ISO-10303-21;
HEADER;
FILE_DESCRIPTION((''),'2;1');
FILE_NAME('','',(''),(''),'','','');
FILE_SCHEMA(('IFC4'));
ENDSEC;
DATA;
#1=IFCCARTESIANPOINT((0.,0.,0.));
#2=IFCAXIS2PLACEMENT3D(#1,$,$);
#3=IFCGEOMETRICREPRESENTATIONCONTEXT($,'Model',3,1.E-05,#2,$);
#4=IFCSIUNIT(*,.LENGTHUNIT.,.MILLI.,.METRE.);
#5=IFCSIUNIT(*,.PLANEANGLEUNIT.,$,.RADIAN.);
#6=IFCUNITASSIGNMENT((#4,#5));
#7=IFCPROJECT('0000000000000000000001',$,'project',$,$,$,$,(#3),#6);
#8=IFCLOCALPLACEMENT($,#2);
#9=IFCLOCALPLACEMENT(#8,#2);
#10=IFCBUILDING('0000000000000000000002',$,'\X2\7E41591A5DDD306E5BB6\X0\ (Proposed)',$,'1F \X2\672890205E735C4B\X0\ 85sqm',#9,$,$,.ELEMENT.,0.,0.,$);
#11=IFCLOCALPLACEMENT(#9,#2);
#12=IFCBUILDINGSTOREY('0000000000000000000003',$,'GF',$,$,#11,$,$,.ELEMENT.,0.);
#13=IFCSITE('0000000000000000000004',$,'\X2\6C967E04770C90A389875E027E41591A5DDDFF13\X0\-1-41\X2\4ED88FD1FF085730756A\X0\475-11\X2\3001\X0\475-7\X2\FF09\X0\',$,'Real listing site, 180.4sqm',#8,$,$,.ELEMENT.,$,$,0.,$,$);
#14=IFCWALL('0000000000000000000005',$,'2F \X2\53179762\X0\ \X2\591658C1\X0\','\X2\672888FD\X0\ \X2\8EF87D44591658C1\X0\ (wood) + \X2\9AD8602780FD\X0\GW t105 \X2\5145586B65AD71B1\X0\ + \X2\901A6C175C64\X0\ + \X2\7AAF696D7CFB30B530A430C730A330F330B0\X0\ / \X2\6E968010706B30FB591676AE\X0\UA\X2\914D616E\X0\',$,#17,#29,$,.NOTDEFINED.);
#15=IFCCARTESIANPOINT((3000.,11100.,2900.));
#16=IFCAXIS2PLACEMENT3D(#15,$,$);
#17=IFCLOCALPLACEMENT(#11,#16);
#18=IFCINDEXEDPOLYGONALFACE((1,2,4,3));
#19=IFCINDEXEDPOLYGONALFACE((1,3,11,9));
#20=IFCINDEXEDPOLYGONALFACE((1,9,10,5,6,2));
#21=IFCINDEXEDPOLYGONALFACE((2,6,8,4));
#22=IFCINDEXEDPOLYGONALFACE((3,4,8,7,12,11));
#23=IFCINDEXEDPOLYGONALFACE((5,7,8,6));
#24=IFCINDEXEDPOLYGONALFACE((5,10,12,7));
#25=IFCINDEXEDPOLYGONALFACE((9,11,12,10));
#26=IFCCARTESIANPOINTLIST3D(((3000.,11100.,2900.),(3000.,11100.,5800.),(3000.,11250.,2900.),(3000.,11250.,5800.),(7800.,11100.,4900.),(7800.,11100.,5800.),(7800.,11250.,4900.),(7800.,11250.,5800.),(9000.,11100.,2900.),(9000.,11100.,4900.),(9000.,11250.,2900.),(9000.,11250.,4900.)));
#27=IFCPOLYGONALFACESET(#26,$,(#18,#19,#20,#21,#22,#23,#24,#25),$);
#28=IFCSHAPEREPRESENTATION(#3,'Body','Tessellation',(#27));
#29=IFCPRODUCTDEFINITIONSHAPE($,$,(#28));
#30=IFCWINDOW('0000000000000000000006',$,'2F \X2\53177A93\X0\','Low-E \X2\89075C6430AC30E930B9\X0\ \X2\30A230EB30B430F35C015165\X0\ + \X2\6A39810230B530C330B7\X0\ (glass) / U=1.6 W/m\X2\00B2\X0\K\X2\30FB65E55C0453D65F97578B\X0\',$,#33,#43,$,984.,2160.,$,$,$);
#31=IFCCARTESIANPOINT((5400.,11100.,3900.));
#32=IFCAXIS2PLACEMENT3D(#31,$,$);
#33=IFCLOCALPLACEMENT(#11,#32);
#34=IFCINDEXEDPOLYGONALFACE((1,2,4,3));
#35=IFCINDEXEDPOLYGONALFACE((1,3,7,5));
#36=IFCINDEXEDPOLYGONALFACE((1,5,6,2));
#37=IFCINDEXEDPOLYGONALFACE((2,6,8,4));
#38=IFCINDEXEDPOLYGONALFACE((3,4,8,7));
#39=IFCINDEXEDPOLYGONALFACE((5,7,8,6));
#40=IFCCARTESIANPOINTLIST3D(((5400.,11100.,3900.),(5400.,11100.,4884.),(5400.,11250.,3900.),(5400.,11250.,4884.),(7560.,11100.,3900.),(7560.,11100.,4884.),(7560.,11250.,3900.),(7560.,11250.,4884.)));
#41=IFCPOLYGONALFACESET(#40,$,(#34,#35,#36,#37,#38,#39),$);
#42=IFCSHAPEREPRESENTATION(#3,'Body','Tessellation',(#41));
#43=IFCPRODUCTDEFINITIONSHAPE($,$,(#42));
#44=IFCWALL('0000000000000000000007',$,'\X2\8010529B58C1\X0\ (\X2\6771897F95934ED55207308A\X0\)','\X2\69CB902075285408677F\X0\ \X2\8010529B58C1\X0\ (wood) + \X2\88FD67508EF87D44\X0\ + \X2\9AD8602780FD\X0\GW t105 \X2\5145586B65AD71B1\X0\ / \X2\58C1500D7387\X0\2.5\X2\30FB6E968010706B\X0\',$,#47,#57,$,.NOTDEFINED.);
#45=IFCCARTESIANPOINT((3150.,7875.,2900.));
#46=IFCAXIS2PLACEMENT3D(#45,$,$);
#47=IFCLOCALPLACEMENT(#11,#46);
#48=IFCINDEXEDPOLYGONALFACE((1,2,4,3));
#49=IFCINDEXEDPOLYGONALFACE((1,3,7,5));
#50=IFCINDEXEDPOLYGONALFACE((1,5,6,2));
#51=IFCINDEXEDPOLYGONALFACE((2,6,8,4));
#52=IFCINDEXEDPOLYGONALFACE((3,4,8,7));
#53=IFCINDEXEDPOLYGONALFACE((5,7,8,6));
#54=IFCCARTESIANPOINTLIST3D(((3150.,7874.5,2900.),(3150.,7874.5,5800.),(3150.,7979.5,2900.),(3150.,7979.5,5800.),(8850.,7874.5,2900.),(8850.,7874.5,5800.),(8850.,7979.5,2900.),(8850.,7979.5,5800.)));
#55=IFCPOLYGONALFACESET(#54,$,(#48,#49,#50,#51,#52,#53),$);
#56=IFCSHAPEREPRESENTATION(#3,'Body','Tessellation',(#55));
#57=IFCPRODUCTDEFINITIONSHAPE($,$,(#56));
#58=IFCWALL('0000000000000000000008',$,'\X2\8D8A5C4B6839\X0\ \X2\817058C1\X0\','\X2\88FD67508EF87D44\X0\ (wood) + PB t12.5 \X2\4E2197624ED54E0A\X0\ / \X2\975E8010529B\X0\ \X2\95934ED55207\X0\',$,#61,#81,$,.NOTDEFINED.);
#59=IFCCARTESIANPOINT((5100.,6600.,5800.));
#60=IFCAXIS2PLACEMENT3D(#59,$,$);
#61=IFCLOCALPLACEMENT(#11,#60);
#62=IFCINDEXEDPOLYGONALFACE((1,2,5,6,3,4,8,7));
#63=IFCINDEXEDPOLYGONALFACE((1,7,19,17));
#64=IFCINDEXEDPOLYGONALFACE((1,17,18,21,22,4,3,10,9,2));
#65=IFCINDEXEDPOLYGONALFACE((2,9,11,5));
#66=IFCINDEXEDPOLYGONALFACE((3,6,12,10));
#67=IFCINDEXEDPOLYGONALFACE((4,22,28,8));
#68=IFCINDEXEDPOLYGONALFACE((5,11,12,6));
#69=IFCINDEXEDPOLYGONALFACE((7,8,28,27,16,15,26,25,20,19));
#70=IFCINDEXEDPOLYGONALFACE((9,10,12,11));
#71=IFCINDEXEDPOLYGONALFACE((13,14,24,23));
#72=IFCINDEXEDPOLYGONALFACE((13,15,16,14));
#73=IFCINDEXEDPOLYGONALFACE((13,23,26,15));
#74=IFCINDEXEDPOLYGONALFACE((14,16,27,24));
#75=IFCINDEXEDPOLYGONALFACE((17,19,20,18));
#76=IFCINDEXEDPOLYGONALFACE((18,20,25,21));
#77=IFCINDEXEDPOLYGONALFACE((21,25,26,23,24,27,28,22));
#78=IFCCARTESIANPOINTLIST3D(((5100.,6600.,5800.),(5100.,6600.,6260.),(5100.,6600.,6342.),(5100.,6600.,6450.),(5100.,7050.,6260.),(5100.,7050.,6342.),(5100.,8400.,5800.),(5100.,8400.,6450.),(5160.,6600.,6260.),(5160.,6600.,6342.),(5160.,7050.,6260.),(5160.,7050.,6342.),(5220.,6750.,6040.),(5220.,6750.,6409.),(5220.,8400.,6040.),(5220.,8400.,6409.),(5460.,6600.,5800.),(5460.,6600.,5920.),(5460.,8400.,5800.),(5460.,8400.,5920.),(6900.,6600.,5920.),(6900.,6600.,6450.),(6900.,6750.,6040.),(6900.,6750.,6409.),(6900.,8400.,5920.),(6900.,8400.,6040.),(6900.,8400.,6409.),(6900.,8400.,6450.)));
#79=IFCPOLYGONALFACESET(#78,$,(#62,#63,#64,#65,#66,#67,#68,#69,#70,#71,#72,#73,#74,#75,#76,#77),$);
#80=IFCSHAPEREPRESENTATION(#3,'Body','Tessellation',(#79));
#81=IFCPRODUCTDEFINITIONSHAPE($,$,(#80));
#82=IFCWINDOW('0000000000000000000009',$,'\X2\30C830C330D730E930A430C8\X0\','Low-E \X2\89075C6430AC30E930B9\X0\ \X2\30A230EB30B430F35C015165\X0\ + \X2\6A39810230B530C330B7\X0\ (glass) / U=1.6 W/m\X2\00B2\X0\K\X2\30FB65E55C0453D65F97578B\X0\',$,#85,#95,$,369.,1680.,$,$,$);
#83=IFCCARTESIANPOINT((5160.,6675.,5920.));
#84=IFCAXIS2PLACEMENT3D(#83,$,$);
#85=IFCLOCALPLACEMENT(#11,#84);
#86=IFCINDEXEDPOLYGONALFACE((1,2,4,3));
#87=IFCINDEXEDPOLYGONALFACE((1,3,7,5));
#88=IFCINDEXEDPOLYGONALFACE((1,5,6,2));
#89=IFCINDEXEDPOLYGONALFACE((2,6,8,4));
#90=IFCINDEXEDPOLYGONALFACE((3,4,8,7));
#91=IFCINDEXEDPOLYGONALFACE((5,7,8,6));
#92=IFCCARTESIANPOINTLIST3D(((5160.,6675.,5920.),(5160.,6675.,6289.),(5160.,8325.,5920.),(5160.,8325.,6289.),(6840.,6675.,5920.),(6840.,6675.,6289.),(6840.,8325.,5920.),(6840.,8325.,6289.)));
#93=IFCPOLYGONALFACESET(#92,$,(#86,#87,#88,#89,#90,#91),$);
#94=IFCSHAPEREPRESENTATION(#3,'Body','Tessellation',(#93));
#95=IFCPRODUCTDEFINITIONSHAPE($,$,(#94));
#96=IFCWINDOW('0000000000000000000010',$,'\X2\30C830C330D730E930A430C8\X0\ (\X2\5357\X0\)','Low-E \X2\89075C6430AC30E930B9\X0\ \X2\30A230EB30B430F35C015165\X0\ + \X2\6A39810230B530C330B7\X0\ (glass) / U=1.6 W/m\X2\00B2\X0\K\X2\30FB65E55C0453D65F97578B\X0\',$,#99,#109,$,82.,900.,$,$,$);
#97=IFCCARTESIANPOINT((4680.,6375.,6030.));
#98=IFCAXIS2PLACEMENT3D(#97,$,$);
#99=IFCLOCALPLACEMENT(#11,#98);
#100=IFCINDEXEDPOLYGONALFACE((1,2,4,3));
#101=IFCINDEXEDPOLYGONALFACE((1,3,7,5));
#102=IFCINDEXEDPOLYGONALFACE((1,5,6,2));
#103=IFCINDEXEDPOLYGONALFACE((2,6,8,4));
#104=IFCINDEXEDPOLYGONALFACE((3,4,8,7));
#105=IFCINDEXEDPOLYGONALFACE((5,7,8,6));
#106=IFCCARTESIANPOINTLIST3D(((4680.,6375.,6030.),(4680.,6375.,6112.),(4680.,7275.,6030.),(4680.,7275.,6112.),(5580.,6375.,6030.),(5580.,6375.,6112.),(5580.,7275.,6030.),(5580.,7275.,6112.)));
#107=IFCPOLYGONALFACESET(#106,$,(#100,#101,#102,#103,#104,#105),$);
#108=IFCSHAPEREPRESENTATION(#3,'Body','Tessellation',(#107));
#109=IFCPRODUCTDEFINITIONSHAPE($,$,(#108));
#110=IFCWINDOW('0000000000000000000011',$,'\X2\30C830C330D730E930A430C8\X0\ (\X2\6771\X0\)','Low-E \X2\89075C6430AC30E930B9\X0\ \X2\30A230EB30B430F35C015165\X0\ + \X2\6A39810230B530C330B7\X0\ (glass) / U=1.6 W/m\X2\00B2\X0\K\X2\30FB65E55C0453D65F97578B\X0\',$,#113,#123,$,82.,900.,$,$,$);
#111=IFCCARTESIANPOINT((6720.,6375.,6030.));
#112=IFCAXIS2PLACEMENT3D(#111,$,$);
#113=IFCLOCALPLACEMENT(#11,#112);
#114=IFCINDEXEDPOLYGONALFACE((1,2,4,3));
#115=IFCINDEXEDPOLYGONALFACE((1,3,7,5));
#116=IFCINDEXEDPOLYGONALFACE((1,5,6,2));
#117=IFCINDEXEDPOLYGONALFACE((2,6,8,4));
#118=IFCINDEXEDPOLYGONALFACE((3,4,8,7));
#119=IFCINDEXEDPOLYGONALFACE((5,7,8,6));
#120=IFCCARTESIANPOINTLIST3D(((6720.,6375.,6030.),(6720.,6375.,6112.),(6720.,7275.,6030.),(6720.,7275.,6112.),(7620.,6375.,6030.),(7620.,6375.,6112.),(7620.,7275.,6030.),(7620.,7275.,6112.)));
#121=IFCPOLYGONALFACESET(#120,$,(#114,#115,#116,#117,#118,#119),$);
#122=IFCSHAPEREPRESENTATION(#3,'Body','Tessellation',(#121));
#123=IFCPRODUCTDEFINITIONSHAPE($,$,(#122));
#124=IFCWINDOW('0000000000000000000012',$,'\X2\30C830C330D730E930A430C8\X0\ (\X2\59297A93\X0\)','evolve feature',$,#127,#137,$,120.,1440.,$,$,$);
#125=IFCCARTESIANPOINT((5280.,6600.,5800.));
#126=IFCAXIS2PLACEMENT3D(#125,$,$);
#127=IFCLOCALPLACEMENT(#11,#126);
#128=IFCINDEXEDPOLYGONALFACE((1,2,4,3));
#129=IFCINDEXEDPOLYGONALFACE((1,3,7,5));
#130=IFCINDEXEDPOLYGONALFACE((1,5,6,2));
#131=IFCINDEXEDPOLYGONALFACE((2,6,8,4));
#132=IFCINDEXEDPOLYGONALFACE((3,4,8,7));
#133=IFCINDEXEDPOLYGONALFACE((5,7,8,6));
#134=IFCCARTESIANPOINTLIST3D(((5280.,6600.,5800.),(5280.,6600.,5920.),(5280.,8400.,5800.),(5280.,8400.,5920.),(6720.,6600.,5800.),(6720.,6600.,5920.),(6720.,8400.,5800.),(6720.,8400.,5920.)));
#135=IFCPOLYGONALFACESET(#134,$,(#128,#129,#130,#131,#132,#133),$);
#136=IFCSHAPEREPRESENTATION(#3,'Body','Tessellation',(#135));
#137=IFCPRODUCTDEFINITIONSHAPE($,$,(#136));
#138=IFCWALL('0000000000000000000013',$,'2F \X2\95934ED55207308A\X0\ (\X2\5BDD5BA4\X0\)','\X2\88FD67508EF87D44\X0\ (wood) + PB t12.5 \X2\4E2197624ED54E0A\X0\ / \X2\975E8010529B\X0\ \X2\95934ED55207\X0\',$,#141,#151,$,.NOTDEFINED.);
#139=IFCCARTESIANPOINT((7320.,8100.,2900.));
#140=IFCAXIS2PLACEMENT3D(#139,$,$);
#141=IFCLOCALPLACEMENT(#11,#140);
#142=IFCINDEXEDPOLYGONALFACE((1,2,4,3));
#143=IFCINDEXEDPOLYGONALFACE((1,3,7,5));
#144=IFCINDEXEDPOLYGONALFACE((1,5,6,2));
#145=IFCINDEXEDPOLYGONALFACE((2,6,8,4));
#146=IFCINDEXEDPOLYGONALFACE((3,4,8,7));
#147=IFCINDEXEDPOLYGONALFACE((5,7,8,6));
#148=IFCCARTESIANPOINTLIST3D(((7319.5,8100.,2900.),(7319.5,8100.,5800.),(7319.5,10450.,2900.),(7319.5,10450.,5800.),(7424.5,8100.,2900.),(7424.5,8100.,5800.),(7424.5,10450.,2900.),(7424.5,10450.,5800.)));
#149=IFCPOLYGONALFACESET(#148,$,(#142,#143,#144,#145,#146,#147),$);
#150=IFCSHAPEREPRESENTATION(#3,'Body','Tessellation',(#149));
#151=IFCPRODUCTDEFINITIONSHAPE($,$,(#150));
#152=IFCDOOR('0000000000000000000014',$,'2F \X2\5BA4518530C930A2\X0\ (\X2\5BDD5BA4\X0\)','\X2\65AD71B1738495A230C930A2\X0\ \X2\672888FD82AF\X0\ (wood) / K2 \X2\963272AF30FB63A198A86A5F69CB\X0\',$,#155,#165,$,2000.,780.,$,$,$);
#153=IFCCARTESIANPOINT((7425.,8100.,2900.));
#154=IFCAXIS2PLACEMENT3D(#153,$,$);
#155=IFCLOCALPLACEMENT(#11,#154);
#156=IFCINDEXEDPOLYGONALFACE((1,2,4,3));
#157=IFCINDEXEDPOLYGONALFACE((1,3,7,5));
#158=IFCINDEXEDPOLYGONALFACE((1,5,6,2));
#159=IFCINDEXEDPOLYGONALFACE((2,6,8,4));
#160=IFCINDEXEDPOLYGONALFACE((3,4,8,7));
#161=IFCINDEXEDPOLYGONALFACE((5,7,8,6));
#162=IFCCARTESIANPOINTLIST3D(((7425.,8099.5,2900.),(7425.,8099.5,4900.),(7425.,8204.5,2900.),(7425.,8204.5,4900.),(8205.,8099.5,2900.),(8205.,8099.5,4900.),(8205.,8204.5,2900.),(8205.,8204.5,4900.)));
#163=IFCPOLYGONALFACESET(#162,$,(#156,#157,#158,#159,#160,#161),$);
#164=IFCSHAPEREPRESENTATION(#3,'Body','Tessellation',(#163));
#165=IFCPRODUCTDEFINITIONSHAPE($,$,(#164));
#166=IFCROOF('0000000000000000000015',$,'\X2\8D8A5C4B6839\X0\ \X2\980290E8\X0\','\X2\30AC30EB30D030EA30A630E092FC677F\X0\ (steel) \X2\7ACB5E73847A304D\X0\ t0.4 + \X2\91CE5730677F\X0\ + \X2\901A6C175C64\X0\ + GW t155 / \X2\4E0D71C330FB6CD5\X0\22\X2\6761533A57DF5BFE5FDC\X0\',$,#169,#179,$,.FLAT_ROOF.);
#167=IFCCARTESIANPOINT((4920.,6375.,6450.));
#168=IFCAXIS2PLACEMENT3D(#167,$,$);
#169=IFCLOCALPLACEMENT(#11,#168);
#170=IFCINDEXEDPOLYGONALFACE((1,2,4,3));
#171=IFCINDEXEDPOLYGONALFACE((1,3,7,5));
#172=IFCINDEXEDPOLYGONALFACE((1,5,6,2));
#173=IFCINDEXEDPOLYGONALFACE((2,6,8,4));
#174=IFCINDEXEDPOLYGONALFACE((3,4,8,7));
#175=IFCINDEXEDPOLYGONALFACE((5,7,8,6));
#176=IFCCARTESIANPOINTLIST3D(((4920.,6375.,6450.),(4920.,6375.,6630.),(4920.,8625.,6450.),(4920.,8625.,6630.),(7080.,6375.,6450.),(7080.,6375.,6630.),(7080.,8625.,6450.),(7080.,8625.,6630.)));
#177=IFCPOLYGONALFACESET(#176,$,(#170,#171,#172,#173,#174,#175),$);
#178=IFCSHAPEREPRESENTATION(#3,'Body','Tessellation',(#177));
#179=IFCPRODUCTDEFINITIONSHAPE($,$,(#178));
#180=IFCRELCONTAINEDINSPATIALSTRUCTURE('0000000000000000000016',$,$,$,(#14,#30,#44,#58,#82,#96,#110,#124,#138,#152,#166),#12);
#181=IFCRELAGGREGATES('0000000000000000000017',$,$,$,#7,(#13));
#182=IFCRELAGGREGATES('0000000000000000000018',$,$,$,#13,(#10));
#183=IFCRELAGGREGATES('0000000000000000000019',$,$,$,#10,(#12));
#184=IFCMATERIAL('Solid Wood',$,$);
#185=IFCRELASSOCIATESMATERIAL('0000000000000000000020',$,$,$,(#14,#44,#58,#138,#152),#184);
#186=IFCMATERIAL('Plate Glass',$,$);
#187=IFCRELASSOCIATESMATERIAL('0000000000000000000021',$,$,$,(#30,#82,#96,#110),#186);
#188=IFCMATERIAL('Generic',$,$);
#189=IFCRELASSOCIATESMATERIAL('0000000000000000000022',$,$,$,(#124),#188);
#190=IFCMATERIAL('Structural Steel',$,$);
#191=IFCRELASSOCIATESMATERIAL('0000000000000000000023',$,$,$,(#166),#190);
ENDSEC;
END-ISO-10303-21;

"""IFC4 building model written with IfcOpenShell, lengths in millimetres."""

from ifc_helpers import new_model, si_unit, frame, frame_2d, origin, place, context, project, spatial, rectangle, extrude, material, element, fill, save


model = new_model("IFC4")

# Units and contexts
model_context = context("Model", 3, precision=1e-05, world=origin())
ifc_project = project(units=[si_unit("LENGTHUNIT", "METRE", prefix="MILLI"), si_unit("PLANEANGLEUNIT", "RADIAN")], contexts=[model_context])

# Site, building, storey
site_placement = place(None, origin())
site = spatial("IfcSite", under=ifc_project, at=site_placement, Name="沖縄県那覇市繁多川３-1-41付近（地番475-11、475-7）", ObjectType="Real listing site, 180.4sqm", CompositionType="ELEMENT", RefElevation=0.0)
building_placement = place(site_placement, origin())
building = spatial("IfcBuilding", under=site, at=building_placement, Name="繁多川の家 (Proposed)", ObjectType="1F 木造平屋 85sqm", CompositionType="ELEMENT", ElevationOfRefHeight=0.0, ElevationOfTerrain=0.0)
storey_placement = place(building_placement, origin())
storey = spatial("IfcBuildingStorey", under=building, at=storey_placement, Name="GF", CompositionType="ELEMENT", Elevation=0.0)

# Wall, opening, window
ifc_material_1 = material(Name="Solid Wood")
wall_1_placement = place(storey_placement, frame((3000.0, 11100.0, 2900.0)))
wall_1 = element("IfcWall", 1, at=wall_1_placement, inside=storey, material=ifc_material_1, Name="2F 北面 外壁", Description="木製 軸組外壁 (wood) + 高性能GW t105 充填断熱 + 通気層 + 窯業系サイディング / 準耐火・外皮UA配慮", PredefinedType="NOTDEFINED", context=model_context, shape_type="SweptSolid", body=[
    extrude(rectangle(XDim=6000.0, YDim=150.0, at=frame_2d((3000.0, 75.0))), frame((3000.0, 11100.0, 2900.0)), (0.0, 0.0, 1.0), 2900.0),
])
opening_1_placement = place(storey_placement, frame((5400.0, 11100.0, 3900.0)))
opening_1 = element("IfcOpeningElement", 2, at=opening_1_placement, cuts=wall_1, PredefinedType="NOTDEFINED", context=model_context, shape_type="SweptSolid", body=[
    extrude(rectangle(XDim=2160.0, YDim=150.0, at=frame_2d((1080.0, 75.0))), frame((5400.0, 11100.0, 3900.0)), (0.0, 0.0, 1.0), 984.0),
])
ifc_material_2 = material(Name="Plate Glass")
window_1_placement = place(storey_placement, frame((5400.0, 11100.0, 3900.0)))
window_1 = element("IfcWindow", 3, at=window_1_placement, inside=storey, material=ifc_material_2, Name="2F 北窓", Description="Low-E 複層ガラス アルゴン封入 + 樹脂サッシ (glass) / U=1.6 W/m²K・日射取得型", OverallHeight=984.0, OverallWidth=2160.0, context=model_context, shape_type="SweptSolid", body=[
    extrude(rectangle(XDim=2160.0, YDim=150.0, at=frame_2d((1080.0, 75.0))), frame((5400.0, 11100.0, 3900.0)), (0.0, 0.0, 1.0), 984.0),
])
fill(opening_1, window_1)

# Wall
wall_2_placement = place(storey_placement, frame((3150.0, 7875.0, 2900.0)))
element("IfcWall", 4, at=wall_2_placement, inside=storey, material=ifc_material_1, Name="耐力壁 (東西間仕切り)", Description="構造用合板 耐力壁 (wood) + 製材軸組 + 高性能GW t105 充填断熱 / 壁倍率2.5・準耐火", PredefinedType="NOTDEFINED", context=model_context, shape_type="SweptSolid", body=[
    extrude(rectangle(XDim=5700.0, YDim=105.0, at=frame_2d((2850.0, 52.0))), frame((3150.0, 7875.0, 2900.0)), (0.0, 0.0, 1.0), 2900.0),
])

# Wall, openings, windows
wall_3_placement = place(storey_placement, frame((5100.0, 6600.0, 5800.0)))
wall_3 = element("IfcWall", 5, at=wall_3_placement, inside=storey, material=ifc_material_1, Name="越屋根 腰壁", Description="製材軸組 (wood) + PB t12.5 両面仕上 / 非耐力 間仕切", PredefinedType="NOTDEFINED", context=model_context, shape_type="SweptSolid", body=[
    extrude(rectangle(XDim=1800.0, YDim=1800.0, at=frame_2d((900.0, 900.0))), frame((5100.0, 6600.0, 5800.0)), (0.0, 0.0, 1.0), 650.0),
])
opening_2_placement = place(storey_placement, frame((5160.0, 6675.0, 5920.0)))
opening_2 = element("IfcOpeningElement", 6, at=opening_2_placement, cuts=wall_3, PredefinedType="NOTDEFINED", context=model_context, shape_type="SweptSolid", body=[
    extrude(rectangle(XDim=1680.0, YDim=1650.0, at=frame_2d((840.0, 825.0))), frame((5160.0, 6675.0, 5920.0)), (0.0, 0.0, 1.0), 369.0),
])
opening_3_placement = place(storey_placement, frame((4680.0, 6375.0, 6030.0)))
opening_3 = element("IfcOpeningElement", 7, at=opening_3_placement, cuts=wall_3, PredefinedType="NOTDEFINED", context=model_context, shape_type="SweptSolid", body=[
    extrude(rectangle(XDim=900.0, YDim=900.0, at=frame_2d((450.0, 450.0))), frame((4680.0, 6375.0, 6030.0)), (0.0, 0.0, 1.0), 82.0),
])
opening_4_placement = place(storey_placement, frame((6720.0, 6375.0, 6030.0)))
opening_4 = element("IfcOpeningElement", 8, at=opening_4_placement, cuts=wall_3, PredefinedType="NOTDEFINED", context=model_context, shape_type="SweptSolid", body=[
    extrude(rectangle(XDim=900.0, YDim=900.0, at=frame_2d((450.0, 450.0))), frame((6720.0, 6375.0, 6030.0)), (0.0, 0.0, 1.0), 82.0),
])
opening_5_placement = place(storey_placement, frame((5280.0, 6600.0, 5800.0)))
opening_5 = element("IfcOpeningElement", 9, at=opening_5_placement, cuts=wall_3, PredefinedType="NOTDEFINED", context=model_context, shape_type="SweptSolid", body=[
    extrude(rectangle(XDim=1440.0, YDim=1800.0, at=frame_2d((720.0, 900.0))), frame((5280.0, 6600.0, 5800.0)), (0.0, 0.0, 1.0), 120.0),
])
window_2_placement = place(storey_placement, frame((5160.0, 6675.0, 5920.0)))
window_2 = element("IfcWindow", 10, at=window_2_placement, inside=storey, material=ifc_material_2, Name="トップライト", Description="Low-E 複層ガラス アルゴン封入 + 樹脂サッシ (glass) / U=1.6 W/m²K・日射取得型", OverallHeight=369.0, OverallWidth=1680.0, context=model_context, shape_type="SweptSolid", body=[
    extrude(rectangle(XDim=1680.0, YDim=1650.0, at=frame_2d((840.0, 825.0))), frame((5160.0, 6675.0, 5920.0)), (0.0, 0.0, 1.0), 369.0),
])
fill(opening_2, window_2)
window_3_placement = place(storey_placement, frame((4680.0, 6375.0, 6030.0)))
window_3 = element("IfcWindow", 11, at=window_3_placement, inside=storey, material=ifc_material_2, Name="トップライト (南)", Description="Low-E 複層ガラス アルゴン封入 + 樹脂サッシ (glass) / U=1.6 W/m²K・日射取得型", OverallHeight=82.0, OverallWidth=900.0, context=model_context, shape_type="SweptSolid", body=[
    extrude(rectangle(XDim=900.0, YDim=900.0, at=frame_2d((450.0, 450.0))), frame((4680.0, 6375.0, 6030.0)), (0.0, 0.0, 1.0), 82.0),
])
fill(opening_3, window_3)
window_4_placement = place(storey_placement, frame((6720.0, 6375.0, 6030.0)))
window_4 = element("IfcWindow", 12, at=window_4_placement, inside=storey, material=ifc_material_2, Name="トップライト (東)", Description="Low-E 複層ガラス アルゴン封入 + 樹脂サッシ (glass) / U=1.6 W/m²K・日射取得型", OverallHeight=82.0, OverallWidth=900.0, context=model_context, shape_type="SweptSolid", body=[
    extrude(rectangle(XDim=900.0, YDim=900.0, at=frame_2d((450.0, 450.0))), frame((6720.0, 6375.0, 6030.0)), (0.0, 0.0, 1.0), 82.0),
])
fill(opening_4, window_4)
ifc_material_3 = material(Name="Generic")
window_5_placement = place(storey_placement, frame((5280.0, 6600.0, 5800.0)))
window_5 = element("IfcWindow", 13, at=window_5_placement, inside=storey, material=ifc_material_3, Name="トップライト (天窓)", Description="evolve feature", OverallHeight=120.0, OverallWidth=1440.0, context=model_context, shape_type="SweptSolid", body=[
    extrude(rectangle(XDim=1440.0, YDim=1800.0, at=frame_2d((720.0, 900.0))), frame((5280.0, 6600.0, 5800.0)), (0.0, 0.0, 1.0), 120.0),
])
fill(opening_5, window_5)

# Wall
wall_4_placement = place(storey_placement, frame((7320.0, 8100.0, 2900.0)))
element("IfcWall", 14, at=wall_4_placement, inside=storey, material=ifc_material_1, Name="2F 間仕切り (寝室)", Description="製材軸組 (wood) + PB t12.5 両面仕上 / 非耐力 間仕切", PredefinedType="NOTDEFINED", context=model_context, shape_type="SweptSolid", body=[
    extrude(rectangle(XDim=105.0, YDim=2350.0, at=frame_2d((52.0, 1175.0))), frame((7320.0, 8100.0, 2900.0)), (0.0, 0.0, 1.0), 2900.0),
])

# Door
door_placement = place(storey_placement, frame((7425.0, 8100.0, 2900.0)))
element("IfcDoor", 15, at=door_placement, inside=storey, material=ifc_material_1, Name="2F 室内ドア (寝室)", Description="断熱玄関ドア 木製芯 (wood) / K2 防犯・採風機構", OverallHeight=2000.0, OverallWidth=780.0, context=model_context, shape_type="SweptSolid", body=[
    extrude(rectangle(XDim=780.0, YDim=105.0, at=frame_2d((390.0, 52.0))), frame((7425.0, 8100.0, 2900.0)), (0.0, 0.0, 1.0), 2000.0),
])

# Roof
ifc_material_4 = material(Name="Structural Steel")
roof_placement = place(storey_placement, frame((4920.0, 6375.0, 6450.0)))
element("IfcRoof", 16, at=roof_placement, inside=storey, material=ifc_material_4, Name="越屋根 頂部", Description="ガルバリウム鋼板 (steel) 立平葺き t0.4 + 野地板 + 通気層 + GW t155 / 不燃・法22条区域対応", PredefinedType="FLAT_ROOF", context=model_context, shape_type="SweptSolid", body=[
    extrude(rectangle(XDim=2160.0, YDim=2250.0, at=frame_2d((1080.0, 1125.0))), frame((4920.0, 6375.0, 6450.0)), (0.0, 0.0, 1.0), 180.0),
])

save(model, "model.ifc")
